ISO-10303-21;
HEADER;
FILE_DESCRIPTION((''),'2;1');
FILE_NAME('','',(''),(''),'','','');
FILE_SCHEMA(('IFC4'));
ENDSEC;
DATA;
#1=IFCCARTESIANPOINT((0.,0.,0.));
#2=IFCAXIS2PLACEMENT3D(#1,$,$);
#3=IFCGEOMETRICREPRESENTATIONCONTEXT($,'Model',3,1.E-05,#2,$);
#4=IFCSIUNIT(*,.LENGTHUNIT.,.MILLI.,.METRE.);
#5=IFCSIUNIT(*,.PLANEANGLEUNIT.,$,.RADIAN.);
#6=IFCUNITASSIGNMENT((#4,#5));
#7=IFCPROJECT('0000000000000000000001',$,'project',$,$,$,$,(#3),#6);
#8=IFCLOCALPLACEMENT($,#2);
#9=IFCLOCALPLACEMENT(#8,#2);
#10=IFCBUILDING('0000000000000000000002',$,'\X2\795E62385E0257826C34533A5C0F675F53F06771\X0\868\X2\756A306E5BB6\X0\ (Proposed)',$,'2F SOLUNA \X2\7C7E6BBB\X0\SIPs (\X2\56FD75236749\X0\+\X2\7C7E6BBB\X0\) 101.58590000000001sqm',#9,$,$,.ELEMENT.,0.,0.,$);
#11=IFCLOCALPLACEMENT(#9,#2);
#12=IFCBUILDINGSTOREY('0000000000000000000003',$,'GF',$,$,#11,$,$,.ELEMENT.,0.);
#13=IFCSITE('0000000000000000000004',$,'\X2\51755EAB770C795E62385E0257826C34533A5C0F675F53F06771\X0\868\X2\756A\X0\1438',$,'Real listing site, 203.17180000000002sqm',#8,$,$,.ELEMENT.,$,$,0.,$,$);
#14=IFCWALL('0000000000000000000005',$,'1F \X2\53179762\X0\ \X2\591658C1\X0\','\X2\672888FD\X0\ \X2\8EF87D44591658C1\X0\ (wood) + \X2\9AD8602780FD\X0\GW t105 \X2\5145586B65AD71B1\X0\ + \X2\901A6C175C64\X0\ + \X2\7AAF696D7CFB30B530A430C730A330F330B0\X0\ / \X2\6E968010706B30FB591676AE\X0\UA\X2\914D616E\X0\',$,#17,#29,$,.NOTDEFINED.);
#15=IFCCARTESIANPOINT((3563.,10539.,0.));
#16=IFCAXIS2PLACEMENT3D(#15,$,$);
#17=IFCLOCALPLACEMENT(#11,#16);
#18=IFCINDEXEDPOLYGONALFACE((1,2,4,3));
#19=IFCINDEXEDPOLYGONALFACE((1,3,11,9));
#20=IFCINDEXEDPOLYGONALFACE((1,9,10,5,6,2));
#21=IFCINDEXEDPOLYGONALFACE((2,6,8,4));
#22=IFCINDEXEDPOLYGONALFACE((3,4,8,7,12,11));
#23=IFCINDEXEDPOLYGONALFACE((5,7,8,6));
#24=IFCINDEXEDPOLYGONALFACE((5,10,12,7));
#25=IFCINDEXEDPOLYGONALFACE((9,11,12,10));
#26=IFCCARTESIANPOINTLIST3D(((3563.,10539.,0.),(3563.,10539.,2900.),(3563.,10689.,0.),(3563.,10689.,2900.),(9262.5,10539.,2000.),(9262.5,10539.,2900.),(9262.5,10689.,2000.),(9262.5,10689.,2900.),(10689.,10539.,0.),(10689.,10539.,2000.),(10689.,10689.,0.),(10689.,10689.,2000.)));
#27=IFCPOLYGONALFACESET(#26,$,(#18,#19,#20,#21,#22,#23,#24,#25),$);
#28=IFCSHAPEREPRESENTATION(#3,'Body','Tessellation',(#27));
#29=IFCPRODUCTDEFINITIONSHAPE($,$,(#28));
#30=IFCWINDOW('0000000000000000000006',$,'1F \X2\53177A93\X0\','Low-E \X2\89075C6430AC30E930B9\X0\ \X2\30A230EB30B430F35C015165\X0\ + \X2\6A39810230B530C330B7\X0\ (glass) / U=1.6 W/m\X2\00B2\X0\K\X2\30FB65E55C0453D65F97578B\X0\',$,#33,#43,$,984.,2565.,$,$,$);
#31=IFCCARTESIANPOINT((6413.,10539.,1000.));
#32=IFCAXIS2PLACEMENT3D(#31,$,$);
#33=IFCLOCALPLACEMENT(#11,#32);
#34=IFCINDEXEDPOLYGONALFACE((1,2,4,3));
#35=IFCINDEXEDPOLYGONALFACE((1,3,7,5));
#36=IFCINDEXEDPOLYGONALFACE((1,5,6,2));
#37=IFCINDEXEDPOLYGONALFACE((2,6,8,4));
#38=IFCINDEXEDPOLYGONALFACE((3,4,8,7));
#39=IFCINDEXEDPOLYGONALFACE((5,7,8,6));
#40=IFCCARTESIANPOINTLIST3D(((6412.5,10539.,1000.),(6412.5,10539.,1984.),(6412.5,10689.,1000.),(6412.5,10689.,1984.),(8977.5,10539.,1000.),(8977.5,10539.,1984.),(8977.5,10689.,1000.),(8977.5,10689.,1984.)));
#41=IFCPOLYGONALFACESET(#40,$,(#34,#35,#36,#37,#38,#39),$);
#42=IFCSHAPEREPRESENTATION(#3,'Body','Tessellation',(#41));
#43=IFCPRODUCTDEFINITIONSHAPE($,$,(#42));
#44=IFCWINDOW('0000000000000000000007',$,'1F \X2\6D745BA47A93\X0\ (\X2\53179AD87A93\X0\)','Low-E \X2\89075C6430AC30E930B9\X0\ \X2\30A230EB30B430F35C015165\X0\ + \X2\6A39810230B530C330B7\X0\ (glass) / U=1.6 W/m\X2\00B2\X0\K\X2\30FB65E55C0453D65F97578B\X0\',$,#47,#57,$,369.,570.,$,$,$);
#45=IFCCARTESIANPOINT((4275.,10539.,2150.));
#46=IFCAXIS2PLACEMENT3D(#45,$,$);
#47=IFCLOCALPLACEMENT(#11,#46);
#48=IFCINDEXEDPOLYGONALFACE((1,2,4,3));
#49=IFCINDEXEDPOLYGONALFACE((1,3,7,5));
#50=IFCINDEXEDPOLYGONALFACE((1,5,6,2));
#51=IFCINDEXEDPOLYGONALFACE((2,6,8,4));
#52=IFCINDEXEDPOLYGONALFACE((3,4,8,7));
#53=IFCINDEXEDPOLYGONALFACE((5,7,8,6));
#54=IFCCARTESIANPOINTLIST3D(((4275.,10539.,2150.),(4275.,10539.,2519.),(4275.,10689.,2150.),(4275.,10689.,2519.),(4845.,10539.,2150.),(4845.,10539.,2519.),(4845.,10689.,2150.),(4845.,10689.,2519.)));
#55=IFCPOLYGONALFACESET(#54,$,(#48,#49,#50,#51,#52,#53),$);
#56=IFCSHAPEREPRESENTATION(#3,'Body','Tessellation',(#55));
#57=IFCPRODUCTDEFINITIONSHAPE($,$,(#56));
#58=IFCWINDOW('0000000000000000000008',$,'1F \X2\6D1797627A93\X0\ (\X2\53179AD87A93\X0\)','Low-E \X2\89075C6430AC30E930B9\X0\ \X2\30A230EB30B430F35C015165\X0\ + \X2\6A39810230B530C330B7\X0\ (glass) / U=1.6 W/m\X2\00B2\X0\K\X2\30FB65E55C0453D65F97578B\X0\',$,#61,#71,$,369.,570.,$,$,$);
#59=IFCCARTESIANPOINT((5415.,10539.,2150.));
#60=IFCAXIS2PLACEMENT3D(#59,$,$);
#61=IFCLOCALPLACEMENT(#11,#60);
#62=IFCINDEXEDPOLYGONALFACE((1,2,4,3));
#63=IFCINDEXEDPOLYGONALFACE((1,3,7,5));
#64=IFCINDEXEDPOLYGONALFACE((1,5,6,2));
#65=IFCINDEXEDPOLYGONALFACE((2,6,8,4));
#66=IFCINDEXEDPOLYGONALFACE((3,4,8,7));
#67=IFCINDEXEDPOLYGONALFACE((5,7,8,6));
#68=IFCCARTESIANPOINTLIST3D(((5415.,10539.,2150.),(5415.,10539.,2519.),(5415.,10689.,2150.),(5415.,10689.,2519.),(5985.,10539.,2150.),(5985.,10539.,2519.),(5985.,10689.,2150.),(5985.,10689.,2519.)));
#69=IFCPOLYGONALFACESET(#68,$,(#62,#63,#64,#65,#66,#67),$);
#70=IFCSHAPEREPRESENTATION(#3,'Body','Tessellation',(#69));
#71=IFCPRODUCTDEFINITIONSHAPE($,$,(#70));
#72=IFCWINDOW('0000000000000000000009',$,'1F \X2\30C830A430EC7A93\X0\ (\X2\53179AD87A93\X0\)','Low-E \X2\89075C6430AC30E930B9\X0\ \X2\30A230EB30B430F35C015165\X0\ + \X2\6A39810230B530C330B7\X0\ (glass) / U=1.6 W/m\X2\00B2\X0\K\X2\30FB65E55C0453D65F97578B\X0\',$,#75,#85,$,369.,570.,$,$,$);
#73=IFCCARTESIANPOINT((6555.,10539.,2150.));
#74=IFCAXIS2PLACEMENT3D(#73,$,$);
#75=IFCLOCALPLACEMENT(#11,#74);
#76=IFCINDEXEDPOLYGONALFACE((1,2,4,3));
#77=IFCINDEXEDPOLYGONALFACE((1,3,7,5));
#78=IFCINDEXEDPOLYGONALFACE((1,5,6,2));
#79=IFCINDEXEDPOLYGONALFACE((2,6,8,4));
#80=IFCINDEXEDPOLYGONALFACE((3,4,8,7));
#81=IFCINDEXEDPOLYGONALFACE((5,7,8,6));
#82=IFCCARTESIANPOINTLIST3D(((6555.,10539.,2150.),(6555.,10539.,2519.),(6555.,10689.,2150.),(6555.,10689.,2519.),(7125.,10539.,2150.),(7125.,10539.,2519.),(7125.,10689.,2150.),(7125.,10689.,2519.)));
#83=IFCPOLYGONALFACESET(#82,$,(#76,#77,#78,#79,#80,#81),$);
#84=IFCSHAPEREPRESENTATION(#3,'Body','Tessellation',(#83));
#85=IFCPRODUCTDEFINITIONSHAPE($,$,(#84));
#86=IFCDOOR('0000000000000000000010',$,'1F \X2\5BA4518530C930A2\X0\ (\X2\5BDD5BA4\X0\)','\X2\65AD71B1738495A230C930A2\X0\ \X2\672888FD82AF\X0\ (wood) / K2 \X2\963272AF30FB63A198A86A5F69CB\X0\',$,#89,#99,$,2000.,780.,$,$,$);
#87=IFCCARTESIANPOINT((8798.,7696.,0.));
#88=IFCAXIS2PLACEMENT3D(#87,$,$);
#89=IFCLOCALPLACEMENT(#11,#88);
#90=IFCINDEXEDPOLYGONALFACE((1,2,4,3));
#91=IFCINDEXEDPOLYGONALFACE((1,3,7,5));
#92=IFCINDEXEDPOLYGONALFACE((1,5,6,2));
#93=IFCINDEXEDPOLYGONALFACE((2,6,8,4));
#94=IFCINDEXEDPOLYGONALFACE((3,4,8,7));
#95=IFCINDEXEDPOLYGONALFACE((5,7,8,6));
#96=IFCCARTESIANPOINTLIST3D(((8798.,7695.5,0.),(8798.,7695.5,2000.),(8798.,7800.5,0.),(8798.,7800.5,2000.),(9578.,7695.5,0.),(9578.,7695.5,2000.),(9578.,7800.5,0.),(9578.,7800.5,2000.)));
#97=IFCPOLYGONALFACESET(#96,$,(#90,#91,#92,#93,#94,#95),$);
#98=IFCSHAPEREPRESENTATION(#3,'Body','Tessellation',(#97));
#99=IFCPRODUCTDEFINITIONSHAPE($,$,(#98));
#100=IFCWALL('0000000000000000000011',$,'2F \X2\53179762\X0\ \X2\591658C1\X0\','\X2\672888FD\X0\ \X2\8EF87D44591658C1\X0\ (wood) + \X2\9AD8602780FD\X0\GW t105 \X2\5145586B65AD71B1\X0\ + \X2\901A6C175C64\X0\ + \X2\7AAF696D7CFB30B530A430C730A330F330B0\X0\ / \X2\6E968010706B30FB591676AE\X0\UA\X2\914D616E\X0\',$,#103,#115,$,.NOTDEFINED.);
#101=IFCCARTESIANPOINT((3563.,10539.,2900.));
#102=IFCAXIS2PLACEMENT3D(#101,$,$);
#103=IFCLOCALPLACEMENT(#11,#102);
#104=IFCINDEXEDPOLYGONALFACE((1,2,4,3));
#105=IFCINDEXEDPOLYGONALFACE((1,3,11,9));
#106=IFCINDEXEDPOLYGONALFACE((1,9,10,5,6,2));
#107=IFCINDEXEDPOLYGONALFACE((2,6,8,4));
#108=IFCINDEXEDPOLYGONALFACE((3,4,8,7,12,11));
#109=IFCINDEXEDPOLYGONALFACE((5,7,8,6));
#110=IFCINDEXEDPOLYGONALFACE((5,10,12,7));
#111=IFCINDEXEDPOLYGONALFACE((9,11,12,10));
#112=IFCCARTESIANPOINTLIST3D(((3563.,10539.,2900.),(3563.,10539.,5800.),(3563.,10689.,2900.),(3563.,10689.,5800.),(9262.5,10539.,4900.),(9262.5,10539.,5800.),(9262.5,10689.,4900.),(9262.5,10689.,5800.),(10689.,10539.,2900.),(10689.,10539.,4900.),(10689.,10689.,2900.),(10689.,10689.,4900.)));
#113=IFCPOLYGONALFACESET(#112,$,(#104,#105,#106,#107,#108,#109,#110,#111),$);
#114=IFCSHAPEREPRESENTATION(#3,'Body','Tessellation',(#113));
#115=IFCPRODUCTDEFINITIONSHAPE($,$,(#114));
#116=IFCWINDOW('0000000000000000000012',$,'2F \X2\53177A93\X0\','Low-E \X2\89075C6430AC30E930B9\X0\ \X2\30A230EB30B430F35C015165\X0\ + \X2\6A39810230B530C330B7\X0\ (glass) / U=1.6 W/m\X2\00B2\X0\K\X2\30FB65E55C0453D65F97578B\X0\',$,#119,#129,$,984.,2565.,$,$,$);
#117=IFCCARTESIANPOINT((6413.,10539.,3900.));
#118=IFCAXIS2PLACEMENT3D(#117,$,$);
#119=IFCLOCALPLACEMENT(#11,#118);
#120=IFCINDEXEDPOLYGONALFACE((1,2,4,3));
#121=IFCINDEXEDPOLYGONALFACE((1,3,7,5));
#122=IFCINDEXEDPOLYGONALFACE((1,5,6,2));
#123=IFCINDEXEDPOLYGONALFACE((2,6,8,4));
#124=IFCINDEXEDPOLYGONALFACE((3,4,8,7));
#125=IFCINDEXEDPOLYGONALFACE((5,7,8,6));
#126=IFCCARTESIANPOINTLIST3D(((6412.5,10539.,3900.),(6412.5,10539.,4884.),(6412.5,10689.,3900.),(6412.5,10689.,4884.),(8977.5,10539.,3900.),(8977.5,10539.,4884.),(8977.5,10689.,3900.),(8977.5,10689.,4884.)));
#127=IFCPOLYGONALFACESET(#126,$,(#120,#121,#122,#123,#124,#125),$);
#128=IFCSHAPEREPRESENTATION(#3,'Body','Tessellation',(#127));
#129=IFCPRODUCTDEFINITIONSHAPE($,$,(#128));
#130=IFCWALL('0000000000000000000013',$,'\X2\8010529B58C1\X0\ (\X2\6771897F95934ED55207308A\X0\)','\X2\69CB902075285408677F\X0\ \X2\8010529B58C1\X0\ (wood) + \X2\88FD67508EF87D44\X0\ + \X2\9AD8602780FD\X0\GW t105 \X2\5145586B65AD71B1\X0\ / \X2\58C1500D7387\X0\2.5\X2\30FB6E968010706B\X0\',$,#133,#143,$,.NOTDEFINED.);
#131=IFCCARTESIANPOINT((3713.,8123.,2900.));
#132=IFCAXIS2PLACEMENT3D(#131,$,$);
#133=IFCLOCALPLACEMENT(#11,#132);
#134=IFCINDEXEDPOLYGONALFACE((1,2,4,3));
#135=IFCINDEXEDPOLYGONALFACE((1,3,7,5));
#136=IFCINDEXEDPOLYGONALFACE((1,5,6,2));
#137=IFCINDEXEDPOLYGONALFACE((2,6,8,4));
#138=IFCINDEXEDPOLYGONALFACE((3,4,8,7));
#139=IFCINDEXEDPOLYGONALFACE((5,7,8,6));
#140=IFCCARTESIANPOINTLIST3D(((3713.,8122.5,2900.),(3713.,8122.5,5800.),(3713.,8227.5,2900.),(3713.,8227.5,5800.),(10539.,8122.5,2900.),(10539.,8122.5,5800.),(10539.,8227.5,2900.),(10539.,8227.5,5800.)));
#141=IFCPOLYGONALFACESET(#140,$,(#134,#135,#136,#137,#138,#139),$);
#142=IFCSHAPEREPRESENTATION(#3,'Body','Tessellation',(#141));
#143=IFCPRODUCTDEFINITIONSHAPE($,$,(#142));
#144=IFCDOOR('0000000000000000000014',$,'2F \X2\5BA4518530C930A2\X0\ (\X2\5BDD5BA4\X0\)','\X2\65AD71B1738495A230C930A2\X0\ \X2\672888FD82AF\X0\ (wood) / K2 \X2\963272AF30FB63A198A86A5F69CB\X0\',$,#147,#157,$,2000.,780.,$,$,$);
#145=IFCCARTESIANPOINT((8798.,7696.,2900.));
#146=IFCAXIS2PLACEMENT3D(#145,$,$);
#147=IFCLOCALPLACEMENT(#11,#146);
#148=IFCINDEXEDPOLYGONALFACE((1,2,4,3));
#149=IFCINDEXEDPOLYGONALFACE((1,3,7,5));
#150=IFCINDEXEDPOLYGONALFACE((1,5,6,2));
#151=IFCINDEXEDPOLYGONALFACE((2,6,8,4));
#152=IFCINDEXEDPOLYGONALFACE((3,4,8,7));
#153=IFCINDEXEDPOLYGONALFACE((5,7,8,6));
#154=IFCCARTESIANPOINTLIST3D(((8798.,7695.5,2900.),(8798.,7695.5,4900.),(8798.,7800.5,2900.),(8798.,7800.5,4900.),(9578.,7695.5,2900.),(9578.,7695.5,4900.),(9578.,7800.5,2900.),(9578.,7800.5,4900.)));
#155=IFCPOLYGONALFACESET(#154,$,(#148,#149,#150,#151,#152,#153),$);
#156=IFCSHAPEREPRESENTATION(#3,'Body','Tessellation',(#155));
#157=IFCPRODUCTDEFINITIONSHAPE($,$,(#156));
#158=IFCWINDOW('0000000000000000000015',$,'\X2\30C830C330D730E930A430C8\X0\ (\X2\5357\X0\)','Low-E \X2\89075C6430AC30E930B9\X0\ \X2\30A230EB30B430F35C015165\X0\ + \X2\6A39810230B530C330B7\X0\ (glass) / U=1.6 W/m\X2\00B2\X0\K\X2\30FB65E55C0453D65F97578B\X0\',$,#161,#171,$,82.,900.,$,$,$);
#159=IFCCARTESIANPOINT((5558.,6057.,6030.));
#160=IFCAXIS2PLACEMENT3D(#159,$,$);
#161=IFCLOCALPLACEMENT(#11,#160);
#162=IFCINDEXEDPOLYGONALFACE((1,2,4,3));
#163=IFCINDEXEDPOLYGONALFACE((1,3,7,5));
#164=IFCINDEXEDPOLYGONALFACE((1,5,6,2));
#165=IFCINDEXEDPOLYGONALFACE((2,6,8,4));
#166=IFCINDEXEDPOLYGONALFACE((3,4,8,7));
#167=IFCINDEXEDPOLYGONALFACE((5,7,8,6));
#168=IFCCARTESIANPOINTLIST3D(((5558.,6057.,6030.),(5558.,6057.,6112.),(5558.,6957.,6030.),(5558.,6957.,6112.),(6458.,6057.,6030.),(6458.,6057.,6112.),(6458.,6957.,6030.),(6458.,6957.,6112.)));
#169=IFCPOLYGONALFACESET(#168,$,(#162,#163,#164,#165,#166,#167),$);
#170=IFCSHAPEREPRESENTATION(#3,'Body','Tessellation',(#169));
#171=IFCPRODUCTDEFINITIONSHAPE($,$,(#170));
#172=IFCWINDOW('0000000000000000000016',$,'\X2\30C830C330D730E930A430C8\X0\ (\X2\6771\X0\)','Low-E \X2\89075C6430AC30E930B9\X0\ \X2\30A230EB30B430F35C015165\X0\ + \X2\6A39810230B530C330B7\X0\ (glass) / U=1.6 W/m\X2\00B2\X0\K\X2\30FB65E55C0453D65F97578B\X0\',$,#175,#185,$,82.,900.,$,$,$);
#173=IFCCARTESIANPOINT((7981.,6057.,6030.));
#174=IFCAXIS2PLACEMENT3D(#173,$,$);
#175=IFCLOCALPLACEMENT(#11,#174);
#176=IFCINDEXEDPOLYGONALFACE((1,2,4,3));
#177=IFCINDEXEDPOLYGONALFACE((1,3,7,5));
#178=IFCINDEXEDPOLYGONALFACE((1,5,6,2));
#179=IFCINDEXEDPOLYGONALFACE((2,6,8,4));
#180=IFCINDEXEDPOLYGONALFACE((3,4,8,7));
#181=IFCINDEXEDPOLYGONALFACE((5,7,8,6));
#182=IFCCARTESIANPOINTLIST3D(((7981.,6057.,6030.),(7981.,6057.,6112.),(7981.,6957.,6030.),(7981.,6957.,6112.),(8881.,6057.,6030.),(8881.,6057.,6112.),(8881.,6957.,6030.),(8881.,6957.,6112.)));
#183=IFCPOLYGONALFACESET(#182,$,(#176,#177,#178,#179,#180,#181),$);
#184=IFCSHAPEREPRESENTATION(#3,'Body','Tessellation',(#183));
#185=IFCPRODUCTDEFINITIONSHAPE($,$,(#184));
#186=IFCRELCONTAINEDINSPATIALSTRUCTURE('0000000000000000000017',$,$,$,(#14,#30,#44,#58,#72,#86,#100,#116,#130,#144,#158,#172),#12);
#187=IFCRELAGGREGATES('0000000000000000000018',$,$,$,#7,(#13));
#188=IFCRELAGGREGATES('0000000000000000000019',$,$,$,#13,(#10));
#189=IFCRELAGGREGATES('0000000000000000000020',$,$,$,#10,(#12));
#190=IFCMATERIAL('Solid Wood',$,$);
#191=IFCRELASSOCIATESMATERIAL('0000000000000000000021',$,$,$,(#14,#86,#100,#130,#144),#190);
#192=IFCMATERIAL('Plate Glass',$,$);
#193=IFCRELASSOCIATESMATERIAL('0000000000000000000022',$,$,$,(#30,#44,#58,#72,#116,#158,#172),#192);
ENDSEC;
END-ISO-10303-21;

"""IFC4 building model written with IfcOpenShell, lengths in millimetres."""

from ifc_helpers import new_model, si_unit, frame, frame_2d, origin, place, context, project, spatial, rectangle, extrude, material, element, fill, save


model = new_model("IFC4")

# Units and contexts
model_context = context("Model", 3, precision=1e-05, world=origin())
ifc_project = project(units=[si_unit("LENGTHUNIT", "METRE", prefix="MILLI"), si_unit("PLANEANGLEUNIT", "RADIAN")], contexts=[model_context])

# Site, building, storey
site_placement = place(None, origin())
site = spatial("IfcSite", under=ifc_project, at=site_placement, Name="兵庫県神戸市垂水区小束台東868番1438", ObjectType="Real listing site, 203.17180000000002sqm", CompositionType="ELEMENT", RefElevation=0.0)
building_placement = place(site_placement, origin())
building = spatial("IfcBuilding", under=site, at=building_placement, Name="神戸市垂水区小束台東868番の家 (Proposed)", ObjectType="2F SOLUNA 籾殻SIPs (国産杉+籾殻) 101.58590000000001sqm", CompositionType="ELEMENT", ElevationOfRefHeight=0.0, ElevationOfTerrain=0.0)
storey_placement = place(building_placement, origin())
storey = spatial("IfcBuildingStorey", under=building, at=storey_placement, Name="GF", CompositionType="ELEMENT", Elevation=0.0)

# Wall, openings, windows
ifc_material_1 = material(Name="Solid Wood")
wall_1_placement = place(storey_placement, frame((3563.0, 10539.0, 0.0)))
wall_1 = element("IfcWall", 1, at=wall_1_placement, inside=storey, material=ifc_material_1, Name="1F 北面 外壁", Description="木製 軸組外壁 (wood) + 高性能GW t105 充填断熱 + 通気層 + 窯業系サイディング / 準耐火・外皮UA配慮", PredefinedType="NOTDEFINED", context=model_context, shape_type="SweptSolid", body=[
    extrude(rectangle(XDim=7126.0, YDim=150.0, at=frame_2d((3563.0, 75.0))), frame((3563.0, 10539.0, 0.0)), (0.0, 0.0, 1.0), 2900.0),
])
opening_1_placement = place(storey_placement, frame((6413.0, 10539.0, 1000.0)))
opening_1 = element("IfcOpeningElement", 2, at=opening_1_placement, cuts=wall_1, PredefinedType="NOTDEFINED", context=model_context, shape_type="SweptSolid", body=[
    extrude(rectangle(XDim=2565.0, YDim=150.0, at=frame_2d((1282.0, 75.0))), frame((6413.0, 10539.0, 1000.0)), (0.0, 0.0, 1.0), 984.0),
])
opening_2_placement = place(storey_placement, frame((4275.0, 10539.0, 2150.0)))
opening_2 = element("IfcOpeningElement", 3, at=opening_2_placement, cuts=wall_1, PredefinedType="NOTDEFINED", context=model_context, shape_type="SweptSolid", body=[
    extrude(rectangle(XDim=570.0, YDim=150.0, at=frame_2d((285.0, 75.0))), frame((4275.0, 10539.0, 2150.0)), (0.0, 0.0, 1.0), 369.0),
])
opening_3_placement = place(storey_placement, frame((5415.0, 10539.0, 2150.0)))
opening_3 = element("IfcOpeningElement", 4, at=opening_3_placement, cuts=wall_1, PredefinedType="NOTDEFINED", context=model_context, shape_type="SweptSolid", body=[
    extrude(rectangle(XDim=570.0, YDim=150.0, at=frame_2d((285.0, 75.0))), frame((5415.0, 10539.0, 2150.0)), (0.0, 0.0, 1.0), 369.0),
])
opening_4_placement = place(storey_placement, frame((6555.0, 10539.0, 2150.0)))
opening_4 = element("IfcOpeningElement", 5, at=opening_4_placement, cuts=wall_1, PredefinedType="NOTDEFINED", context=model_context, shape_type="SweptSolid", body=[
    extrude(rectangle(XDim=570.0, YDim=150.0, at=frame_2d((285.0, 75.0))), frame((6555.0, 10539.0, 2150.0)), (0.0, 0.0, 1.0), 369.0),
])
ifc_material_2 = material(Name="Plate Glass")
window_1_placement = place(storey_placement, frame((6413.0, 10539.0, 1000.0)))
window_1 = element("IfcWindow", 6, at=window_1_placement, inside=storey, material=ifc_material_2, Name="1F 北窓", Description="Low-E 複層ガラス アルゴン封入 + 樹脂サッシ (glass) / U=1.6 W/m²K・日射取得型", OverallHeight=984.0, OverallWidth=2565.0, context=model_context, shape_type="SweptSolid", body=[
    extrude(rectangle(XDim=2565.0, YDim=150.0, at=frame_2d((1282.0, 75.0))), frame((6413.0, 10539.0, 1000.0)), (0.0, 0.0, 1.0), 984.0),
])
fill(opening_1, window_1)
window_2_placement = place(storey_placement, frame((4275.0, 10539.0, 2150.0)))
window_2 = element("IfcWindow", 7, at=window_2_placement, inside=storey, material=ifc_material_2, Name="1F 浴室窓 (北高窓)", Description="Low-E 複層ガラス アルゴン封入 + 樹脂サッシ (glass) / U=1.6 W/m²K・日射取得型", OverallHeight=369.0, OverallWidth=570.0, context=model_context, shape_type="SweptSolid", body=[
    extrude(rectangle(XDim=570.0, YDim=150.0, at=frame_2d((285.0, 75.0))), frame((4275.0, 10539.0, 2150.0)), (0.0, 0.0, 1.0), 369.0),
])
fill(opening_2, window_2)
window_3_placement = place(storey_placement, frame((5415.0, 10539.0, 2150.0)))
window_3 = element("IfcWindow", 8, at=window_3_placement, inside=storey, material=ifc_material_2, Name="1F 洗面窓 (北高窓)", Description="Low-E 複層ガラス アルゴン封入 + 樹脂サッシ (glass) / U=1.6 W/m²K・日射取得型", OverallHeight=369.0, OverallWidth=570.0, context=model_context, shape_type="SweptSolid", body=[
    extrude(rectangle(XDim=570.0, YDim=150.0, at=frame_2d((285.0, 75.0))), frame((5415.0, 10539.0, 2150.0)), (0.0, 0.0, 1.0), 369.0),
])
fill(opening_3, window_3)
window_4_placement = place(storey_placement, frame((6555.0, 10539.0, 2150.0)))
window_4 = element("IfcWindow", 9, at=window_4_placement, inside=storey, material=ifc_material_2, Name="1F トイレ窓 (北高窓)", Description="Low-E 複層ガラス アルゴン封入 + 樹脂サッシ (glass) / U=1.6 W/m²K・日射取得型", OverallHeight=369.0, OverallWidth=570.0, context=model_context, shape_type="SweptSolid", body=[
    extrude(rectangle(XDim=570.0, YDim=150.0, at=frame_2d((285.0, 75.0))), frame((6555.0, 10539.0, 2150.0)), (0.0, 0.0, 1.0), 369.0),
])
fill(opening_4, window_4)

# Door
door_1_placement = place(storey_placement, frame((8798.0, 7696.0, 0.0)))
element("IfcDoor", 10, at=door_1_placement, inside=storey, material=ifc_material_1, Name="1F 室内ドア (寝室)", Description="断熱玄関ドア 木製芯 (wood) / K2 防犯・採風機構", OverallHeight=2000.0, OverallWidth=780.0, context=model_context, shape_type="SweptSolid", body=[
    extrude(rectangle(XDim=780.0, YDim=105.0, at=frame_2d((390.0, 52.0))), frame((8798.0, 7696.0, 0.0)), (0.0, 0.0, 1.0), 2000.0),
])

# Wall, opening, window
wall_2_placement = place(storey_placement, frame((3563.0, 10539.0, 2900.0)))
wall_2 = element("IfcWall", 11, at=wall_2_placement, inside=storey, material=ifc_material_1, Name="2F 北面 外壁", Description="木製 軸組外壁 (wood) + 高性能GW t105 充填断熱 + 通気層 + 窯業系サイディング / 準耐火・外皮UA配慮", PredefinedType="NOTDEFINED", context=model_context, shape_type="SweptSolid", body=[
    extrude(rectangle(XDim=7126.0, YDim=150.0, at=frame_2d((3563.0, 75.0))), frame((3563.0, 10539.0, 2900.0)), (0.0, 0.0, 1.0), 2900.0),
])
opening_5_placement = place(storey_placement, frame((6413.0, 10539.0, 3900.0)))
opening_5 = element("IfcOpeningElement", 12, at=opening_5_placement, cuts=wall_2, PredefinedType="NOTDEFINED", context=model_context, shape_type="SweptSolid", body=[
    extrude(rectangle(XDim=2565.0, YDim=150.0, at=frame_2d((1282.0, 75.0))), frame((6413.0, 10539.0, 3900.0)), (0.0, 0.0, 1.0), 984.0),
])
window_5_placement = place(storey_placement, frame((6413.0, 10539.0, 3900.0)))
window_5 = element("IfcWindow", 13, at=window_5_placement, inside=storey, material=ifc_material_2, Name="2F 北窓", Description="Low-E 複層ガラス アルゴン封入 + 樹脂サッシ (glass) / U=1.6 W/m²K・日射取得型", OverallHeight=984.0, OverallWidth=2565.0, context=model_context, shape_type="SweptSolid", body=[
    extrude(rectangle(XDim=2565.0, YDim=150.0, at=frame_2d((1282.0, 75.0))), frame((6413.0, 10539.0, 3900.0)), (0.0, 0.0, 1.0), 984.0),
])
fill(opening_5, window_5)

# Wall
wall_3_placement = place(storey_placement, frame((3713.0, 8123.0, 2900.0)))
element("IfcWall", 14, at=wall_3_placement, inside=storey, material=ifc_material_1, Name="耐力壁 (東西間仕切り)", Description="構造用合板 耐力壁 (wood) + 製材軸組 + 高性能GW t105 充填断熱 / 壁倍率2.5・準耐火", PredefinedType="NOTDEFINED", context=model_context, shape_type="SweptSolid", body=[
    extrude(rectangle(XDim=6826.0, YDim=105.0, at=frame_2d((3413.0, 52.0))), frame((3713.0, 8123.0, 2900.0)), (0.0, 0.0, 1.0), 2900.0),
])

# Door
door_2_placement = place(storey_placement, frame((8798.0, 7696.0, 2900.0)))
element("IfcDoor", 15, at=door_2_placement, inside=storey, material=ifc_material_1, Name="2F 室内ドア (寝室)", Description="断熱玄関ドア 木製芯 (wood) / K2 防犯・採風機構", OverallHeight=2000.0, OverallWidth=780.0, context=model_context, shape_type="SweptSolid", body=[
    extrude(rectangle(XDim=780.0, YDim=105.0, at=frame_2d((390.0, 52.0))), frame((8798.0, 7696.0, 2900.0)), (0.0, 0.0, 1.0), 2000.0),
])

# Windows
window_6_placement = place(storey_placement, frame((5558.0, 6057.0, 6030.0)))
element("IfcWindow", 16, at=window_6_placement, inside=storey, material=ifc_material_2, Name="トップライト (南)", Description="Low-E 複層ガラス アルゴン封入 + 樹脂サッシ (glass) / U=1.6 W/m²K・日射取得型", OverallHeight=82.0, OverallWidth=900.0, context=model_context, shape_type="SweptSolid", body=[
    extrude(rectangle(XDim=900.0, YDim=900.0, at=frame_2d((450.0, 450.0))), frame((5558.0, 6057.0, 6030.0)), (0.0, 0.0, 1.0), 82.0),
])
window_7_placement = place(storey_placement, frame((7981.0, 6057.0, 6030.0)))
element("IfcWindow", 17, at=window_7_placement, inside=storey, material=ifc_material_2, Name="トップライト (東)", Description="Low-E 複層ガラス アルゴン封入 + 樹脂サッシ (glass) / U=1.6 W/m²K・日射取得型", OverallHeight=82.0, OverallWidth=900.0, context=model_context, shape_type="SweptSolid", body=[
    extrude(rectangle(XDim=900.0, YDim=900.0, at=frame_2d((450.0, 450.0))), frame((7981.0, 6057.0, 6030.0)), (0.0, 0.0, 1.0), 82.0),
])

save(model, "model.ifc")
